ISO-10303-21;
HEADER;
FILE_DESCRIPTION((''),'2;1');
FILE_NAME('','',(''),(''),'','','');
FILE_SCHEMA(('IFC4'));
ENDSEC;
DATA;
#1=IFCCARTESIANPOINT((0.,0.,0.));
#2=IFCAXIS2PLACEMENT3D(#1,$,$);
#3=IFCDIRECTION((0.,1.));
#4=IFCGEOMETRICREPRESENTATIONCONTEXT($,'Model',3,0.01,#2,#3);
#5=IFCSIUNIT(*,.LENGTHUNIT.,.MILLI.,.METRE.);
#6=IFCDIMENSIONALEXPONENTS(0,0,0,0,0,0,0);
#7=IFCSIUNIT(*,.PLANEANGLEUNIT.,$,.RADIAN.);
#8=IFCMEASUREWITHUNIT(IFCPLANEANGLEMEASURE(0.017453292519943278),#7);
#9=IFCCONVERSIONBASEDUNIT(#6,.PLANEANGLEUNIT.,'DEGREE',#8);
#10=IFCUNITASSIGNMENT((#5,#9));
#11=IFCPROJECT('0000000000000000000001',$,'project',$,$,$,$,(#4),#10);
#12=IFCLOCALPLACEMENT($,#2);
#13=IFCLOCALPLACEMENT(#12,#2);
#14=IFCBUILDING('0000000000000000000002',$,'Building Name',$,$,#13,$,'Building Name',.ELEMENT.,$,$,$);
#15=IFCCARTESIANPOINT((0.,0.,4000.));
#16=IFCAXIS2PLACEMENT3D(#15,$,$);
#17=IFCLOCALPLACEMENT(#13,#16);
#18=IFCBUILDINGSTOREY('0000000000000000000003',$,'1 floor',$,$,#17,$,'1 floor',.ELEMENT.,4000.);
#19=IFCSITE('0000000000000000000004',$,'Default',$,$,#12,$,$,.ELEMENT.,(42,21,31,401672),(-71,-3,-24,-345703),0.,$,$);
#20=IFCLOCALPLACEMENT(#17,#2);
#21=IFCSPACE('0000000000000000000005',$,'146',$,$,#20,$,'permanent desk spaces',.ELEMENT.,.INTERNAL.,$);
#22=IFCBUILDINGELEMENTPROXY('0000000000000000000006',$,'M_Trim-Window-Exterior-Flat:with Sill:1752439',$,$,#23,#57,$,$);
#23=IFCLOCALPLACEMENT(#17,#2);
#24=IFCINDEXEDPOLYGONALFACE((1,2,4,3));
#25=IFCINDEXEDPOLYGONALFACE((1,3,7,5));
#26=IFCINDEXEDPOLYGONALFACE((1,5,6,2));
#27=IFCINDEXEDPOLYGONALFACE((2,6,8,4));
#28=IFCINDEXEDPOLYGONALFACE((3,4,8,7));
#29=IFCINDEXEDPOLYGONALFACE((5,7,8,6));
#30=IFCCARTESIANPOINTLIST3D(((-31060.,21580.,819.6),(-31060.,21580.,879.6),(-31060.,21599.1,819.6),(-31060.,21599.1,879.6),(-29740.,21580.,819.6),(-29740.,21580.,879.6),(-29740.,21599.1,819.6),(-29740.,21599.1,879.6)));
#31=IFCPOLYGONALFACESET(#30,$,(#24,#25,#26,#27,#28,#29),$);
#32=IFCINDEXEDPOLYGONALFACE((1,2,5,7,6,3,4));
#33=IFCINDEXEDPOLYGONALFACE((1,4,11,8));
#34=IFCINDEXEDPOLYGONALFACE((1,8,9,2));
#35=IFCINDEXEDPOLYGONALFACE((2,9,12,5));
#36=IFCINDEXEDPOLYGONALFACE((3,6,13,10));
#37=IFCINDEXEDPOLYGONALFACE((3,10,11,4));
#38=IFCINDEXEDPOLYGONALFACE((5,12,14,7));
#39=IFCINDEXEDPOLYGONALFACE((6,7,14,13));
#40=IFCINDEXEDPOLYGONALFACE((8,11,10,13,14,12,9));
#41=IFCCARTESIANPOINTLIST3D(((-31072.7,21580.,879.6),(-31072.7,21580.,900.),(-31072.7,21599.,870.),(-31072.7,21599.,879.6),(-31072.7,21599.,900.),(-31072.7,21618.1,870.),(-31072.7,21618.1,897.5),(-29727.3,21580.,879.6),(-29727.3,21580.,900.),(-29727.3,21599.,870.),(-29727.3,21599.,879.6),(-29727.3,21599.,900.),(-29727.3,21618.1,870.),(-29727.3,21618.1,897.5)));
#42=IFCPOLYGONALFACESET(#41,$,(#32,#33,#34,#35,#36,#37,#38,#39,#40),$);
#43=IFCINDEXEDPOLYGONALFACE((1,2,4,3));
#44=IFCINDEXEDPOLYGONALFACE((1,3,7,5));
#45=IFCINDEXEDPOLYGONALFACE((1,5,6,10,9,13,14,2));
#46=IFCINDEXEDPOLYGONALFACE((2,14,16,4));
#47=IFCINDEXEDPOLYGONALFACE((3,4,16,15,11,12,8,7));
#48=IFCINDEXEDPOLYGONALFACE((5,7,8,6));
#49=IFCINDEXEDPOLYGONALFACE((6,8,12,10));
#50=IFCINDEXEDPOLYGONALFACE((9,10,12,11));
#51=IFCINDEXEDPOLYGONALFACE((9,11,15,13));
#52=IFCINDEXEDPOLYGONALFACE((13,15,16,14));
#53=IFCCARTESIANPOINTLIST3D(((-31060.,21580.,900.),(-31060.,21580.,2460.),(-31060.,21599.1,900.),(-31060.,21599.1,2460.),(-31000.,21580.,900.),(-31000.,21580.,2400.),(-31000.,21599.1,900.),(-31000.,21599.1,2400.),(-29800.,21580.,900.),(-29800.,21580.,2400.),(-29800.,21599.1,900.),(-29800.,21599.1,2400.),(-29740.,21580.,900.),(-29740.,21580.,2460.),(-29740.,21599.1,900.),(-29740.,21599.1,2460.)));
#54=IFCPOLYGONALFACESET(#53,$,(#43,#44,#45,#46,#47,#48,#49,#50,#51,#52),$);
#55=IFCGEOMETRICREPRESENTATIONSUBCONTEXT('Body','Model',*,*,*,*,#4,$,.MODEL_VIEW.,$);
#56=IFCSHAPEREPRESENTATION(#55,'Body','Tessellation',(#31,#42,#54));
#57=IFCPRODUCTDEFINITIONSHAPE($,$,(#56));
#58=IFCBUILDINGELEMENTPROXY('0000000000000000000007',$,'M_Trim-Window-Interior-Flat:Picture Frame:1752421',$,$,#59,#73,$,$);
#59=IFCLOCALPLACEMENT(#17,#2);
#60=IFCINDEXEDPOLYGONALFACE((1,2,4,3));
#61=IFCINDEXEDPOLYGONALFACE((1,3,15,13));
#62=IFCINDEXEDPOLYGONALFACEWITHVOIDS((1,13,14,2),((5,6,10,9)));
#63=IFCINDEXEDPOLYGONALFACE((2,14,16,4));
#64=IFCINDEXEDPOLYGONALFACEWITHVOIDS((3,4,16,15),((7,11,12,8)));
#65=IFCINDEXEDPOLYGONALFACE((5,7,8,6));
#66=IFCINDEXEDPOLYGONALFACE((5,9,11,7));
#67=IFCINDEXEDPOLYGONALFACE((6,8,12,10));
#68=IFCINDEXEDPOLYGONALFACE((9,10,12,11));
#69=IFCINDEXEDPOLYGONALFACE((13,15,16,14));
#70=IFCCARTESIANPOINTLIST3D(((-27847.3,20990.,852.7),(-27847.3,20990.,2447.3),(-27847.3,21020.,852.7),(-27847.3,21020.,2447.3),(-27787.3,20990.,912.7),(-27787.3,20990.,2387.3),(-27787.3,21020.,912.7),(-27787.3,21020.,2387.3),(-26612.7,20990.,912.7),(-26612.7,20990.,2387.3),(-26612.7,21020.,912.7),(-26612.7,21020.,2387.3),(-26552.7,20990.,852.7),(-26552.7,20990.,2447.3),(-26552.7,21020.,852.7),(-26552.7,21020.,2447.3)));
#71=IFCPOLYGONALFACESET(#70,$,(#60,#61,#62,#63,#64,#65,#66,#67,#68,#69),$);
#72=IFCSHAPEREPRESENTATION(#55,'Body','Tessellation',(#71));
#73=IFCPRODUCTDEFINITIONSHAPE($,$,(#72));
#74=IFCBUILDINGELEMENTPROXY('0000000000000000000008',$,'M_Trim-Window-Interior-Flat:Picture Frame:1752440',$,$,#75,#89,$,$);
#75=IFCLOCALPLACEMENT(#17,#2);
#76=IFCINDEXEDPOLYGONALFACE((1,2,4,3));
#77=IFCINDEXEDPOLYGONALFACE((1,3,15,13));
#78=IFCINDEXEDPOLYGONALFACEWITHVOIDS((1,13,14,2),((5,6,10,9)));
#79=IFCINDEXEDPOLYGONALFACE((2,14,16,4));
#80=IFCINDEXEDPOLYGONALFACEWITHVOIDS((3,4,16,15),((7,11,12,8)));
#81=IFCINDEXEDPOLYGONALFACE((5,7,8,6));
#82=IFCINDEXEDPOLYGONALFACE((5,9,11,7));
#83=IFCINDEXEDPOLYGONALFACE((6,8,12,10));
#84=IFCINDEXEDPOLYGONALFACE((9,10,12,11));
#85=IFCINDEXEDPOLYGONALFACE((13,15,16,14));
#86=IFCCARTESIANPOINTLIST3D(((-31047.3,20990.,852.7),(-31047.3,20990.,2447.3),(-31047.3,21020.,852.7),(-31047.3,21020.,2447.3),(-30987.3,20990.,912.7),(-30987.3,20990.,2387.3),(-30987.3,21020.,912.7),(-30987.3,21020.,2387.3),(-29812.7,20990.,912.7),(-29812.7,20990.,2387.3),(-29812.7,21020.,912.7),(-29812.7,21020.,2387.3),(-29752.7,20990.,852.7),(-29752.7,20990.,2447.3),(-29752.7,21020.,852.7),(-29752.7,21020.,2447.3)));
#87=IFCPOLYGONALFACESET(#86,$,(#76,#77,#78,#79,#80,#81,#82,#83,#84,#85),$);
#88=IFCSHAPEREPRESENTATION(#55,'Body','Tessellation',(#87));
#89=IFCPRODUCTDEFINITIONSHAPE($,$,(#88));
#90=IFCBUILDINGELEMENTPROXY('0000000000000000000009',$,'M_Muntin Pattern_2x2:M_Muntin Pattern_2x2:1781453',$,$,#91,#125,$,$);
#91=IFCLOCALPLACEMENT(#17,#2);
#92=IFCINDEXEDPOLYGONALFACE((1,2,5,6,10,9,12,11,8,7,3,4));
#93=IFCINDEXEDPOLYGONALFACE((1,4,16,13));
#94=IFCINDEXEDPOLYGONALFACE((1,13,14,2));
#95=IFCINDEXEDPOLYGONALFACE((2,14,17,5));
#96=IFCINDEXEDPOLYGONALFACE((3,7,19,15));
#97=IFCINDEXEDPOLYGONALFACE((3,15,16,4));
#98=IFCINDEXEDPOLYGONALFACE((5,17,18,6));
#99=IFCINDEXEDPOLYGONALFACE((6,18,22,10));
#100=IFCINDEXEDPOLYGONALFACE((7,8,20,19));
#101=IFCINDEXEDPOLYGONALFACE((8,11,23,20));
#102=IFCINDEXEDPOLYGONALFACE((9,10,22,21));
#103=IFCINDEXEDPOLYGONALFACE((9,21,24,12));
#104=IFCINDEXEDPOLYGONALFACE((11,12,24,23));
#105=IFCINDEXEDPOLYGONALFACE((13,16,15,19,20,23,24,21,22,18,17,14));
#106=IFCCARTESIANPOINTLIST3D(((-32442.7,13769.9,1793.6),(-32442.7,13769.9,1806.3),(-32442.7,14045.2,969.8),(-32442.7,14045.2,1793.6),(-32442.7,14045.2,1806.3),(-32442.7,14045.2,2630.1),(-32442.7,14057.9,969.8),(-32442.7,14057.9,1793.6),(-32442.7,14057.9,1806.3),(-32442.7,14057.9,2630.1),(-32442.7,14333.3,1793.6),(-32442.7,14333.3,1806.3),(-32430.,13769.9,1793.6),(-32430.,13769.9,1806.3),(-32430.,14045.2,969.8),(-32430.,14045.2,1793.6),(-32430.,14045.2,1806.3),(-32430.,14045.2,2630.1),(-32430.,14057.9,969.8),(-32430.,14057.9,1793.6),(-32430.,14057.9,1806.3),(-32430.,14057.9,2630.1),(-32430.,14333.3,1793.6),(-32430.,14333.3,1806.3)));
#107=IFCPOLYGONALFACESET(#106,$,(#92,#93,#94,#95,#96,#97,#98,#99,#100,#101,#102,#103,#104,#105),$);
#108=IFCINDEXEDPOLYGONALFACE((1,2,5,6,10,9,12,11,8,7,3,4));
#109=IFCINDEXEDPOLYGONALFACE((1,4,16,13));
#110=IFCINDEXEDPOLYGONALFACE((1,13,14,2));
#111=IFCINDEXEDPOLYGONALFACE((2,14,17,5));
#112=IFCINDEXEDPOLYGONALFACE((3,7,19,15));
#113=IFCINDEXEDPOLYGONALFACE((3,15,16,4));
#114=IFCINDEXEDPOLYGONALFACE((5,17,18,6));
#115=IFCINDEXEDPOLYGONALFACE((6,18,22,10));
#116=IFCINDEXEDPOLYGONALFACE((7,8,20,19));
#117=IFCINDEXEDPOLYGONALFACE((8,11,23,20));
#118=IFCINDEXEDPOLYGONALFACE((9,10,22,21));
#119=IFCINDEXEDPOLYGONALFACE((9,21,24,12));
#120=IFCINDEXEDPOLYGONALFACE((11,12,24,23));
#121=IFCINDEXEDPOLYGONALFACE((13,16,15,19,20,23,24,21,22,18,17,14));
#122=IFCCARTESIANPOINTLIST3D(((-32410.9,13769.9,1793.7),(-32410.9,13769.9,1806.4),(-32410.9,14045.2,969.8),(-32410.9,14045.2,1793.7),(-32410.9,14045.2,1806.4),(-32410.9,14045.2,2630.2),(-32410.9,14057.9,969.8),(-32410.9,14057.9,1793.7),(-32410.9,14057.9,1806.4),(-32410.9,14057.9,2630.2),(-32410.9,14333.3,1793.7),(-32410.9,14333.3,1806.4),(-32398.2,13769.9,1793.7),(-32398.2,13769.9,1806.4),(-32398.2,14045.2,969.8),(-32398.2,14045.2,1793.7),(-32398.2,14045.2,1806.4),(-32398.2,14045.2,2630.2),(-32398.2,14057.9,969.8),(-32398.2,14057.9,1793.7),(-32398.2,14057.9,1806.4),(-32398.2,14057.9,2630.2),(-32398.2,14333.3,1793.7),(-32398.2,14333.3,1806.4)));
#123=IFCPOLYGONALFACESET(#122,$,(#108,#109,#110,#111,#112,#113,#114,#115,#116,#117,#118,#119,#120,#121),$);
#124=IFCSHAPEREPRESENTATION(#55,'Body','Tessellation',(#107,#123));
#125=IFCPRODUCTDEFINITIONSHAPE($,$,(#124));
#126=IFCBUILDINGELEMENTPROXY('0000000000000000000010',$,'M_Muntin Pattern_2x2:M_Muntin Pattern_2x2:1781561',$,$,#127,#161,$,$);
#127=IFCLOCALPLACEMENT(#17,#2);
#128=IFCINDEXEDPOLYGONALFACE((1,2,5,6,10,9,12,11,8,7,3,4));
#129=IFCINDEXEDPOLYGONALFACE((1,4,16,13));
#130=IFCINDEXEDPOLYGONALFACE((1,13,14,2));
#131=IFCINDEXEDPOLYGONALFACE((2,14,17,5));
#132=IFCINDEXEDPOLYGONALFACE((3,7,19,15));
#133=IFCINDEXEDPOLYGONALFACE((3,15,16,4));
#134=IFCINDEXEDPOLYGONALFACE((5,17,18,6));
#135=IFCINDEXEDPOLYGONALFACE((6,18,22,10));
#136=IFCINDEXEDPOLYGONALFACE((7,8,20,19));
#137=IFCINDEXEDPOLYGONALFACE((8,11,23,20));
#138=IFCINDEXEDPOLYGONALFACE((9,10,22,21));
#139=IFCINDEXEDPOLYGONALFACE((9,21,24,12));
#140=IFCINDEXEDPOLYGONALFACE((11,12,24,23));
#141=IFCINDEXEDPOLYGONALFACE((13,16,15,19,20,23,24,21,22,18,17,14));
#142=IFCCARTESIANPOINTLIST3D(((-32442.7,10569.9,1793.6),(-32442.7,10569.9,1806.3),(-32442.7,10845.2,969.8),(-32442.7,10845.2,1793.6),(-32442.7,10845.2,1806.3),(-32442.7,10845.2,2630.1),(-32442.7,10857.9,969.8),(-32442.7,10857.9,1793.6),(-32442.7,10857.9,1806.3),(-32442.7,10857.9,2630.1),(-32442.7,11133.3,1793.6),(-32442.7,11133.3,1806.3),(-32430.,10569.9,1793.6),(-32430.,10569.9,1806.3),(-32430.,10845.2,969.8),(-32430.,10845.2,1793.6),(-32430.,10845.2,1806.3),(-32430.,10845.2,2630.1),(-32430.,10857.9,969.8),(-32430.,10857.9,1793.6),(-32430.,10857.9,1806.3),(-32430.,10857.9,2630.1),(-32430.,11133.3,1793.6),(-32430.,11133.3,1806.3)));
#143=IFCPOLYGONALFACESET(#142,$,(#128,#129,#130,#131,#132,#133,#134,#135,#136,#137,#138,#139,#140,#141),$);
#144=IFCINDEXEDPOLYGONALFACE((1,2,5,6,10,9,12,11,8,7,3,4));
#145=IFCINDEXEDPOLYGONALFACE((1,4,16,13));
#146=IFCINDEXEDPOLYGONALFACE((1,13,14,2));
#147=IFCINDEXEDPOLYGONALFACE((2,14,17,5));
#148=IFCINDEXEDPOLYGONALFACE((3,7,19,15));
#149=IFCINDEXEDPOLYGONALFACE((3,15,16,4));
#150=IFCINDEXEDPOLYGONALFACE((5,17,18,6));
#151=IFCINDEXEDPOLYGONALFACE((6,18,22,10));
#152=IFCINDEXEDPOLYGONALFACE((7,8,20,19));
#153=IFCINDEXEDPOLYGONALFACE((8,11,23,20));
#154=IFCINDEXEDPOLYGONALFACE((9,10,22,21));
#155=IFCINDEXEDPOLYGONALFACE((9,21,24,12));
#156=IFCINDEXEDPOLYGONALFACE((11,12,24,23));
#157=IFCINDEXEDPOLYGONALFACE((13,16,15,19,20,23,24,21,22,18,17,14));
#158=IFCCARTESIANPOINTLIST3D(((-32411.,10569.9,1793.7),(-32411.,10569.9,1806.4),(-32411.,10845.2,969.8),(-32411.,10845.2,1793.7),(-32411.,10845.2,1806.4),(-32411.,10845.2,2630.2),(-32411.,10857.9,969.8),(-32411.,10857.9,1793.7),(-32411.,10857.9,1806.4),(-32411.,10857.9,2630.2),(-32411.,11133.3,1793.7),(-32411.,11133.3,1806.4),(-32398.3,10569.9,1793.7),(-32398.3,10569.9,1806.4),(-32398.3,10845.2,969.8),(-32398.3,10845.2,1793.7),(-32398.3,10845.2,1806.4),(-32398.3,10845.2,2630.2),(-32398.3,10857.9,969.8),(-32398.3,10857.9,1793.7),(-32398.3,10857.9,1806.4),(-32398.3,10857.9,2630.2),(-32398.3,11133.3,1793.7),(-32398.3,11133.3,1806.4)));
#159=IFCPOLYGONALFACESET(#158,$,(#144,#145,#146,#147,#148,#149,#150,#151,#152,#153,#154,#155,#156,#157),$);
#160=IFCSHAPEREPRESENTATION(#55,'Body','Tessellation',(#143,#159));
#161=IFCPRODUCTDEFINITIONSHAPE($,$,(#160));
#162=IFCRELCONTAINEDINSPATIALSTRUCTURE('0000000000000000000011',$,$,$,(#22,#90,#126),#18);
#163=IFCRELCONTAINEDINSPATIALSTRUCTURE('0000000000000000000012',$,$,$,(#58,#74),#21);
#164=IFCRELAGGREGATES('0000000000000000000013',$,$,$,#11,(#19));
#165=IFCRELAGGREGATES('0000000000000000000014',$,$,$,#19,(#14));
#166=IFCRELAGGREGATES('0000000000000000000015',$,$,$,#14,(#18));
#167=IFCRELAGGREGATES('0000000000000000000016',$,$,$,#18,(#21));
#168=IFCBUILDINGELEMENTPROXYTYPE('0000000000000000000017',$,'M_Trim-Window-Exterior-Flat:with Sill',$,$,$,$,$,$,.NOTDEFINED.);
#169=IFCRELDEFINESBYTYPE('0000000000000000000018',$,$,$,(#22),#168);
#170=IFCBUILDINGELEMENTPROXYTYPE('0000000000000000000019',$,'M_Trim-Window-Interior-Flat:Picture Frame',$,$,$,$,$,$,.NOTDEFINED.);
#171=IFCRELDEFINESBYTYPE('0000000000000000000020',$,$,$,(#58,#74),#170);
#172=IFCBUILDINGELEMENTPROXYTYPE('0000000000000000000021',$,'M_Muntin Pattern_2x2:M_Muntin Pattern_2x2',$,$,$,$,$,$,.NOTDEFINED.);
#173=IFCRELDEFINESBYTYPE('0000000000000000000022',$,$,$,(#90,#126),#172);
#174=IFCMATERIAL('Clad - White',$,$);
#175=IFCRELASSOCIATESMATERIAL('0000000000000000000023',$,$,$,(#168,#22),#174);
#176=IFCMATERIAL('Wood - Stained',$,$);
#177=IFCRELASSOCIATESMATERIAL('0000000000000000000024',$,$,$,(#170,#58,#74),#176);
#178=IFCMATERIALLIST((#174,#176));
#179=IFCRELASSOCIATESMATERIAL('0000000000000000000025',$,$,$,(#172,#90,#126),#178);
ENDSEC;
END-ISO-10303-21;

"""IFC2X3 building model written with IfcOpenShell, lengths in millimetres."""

from ifc_helpers import new_model, entity, si_unit, converted_unit, direction, frame, frame_2d, origin, place, context, subcontext, project, spatial, polyline, rectangle, outline, extrude, source, transform, mapped, material, material_list, type_object, type_shapes, element, save


model = new_model("IFC2X3")

# Units and contexts
model_context = context("Model", 3, precision=0.01, world=origin(), true_north=direction((0.0, 1.0)))
body_context = subcontext(model_context, "Body", "Model", "MODEL_VIEW")
ifc_project = project(units=[si_unit("LENGTHUNIT", "METRE", prefix="MILLI"), converted_unit("PLANEANGLEUNIT", "DEGREE", entity("IfcPlaneAngleMeasure", 0.017453292519943278), si_unit("PLANEANGLEUNIT", "RADIAN"), dimensions=[0, 0, 0, 0, 0, 0, 0])], contexts=[model_context])

# Site, building, storey
site_placement = place(None, origin())
site = spatial("IfcSite", under=ifc_project, at=site_placement, Name="Default", CompositionType="ELEMENT", RefLatitude=(42, 21, 31, 401672), RefLongitude=(-71, -3, -24, -345703), RefElevation=0.0)
building_placement = place(site_placement, origin())
building = spatial("IfcBuilding", under=site, at=building_placement, Name="Building Name", LongName="Building Name", CompositionType="ELEMENT")
storey_placement = place(building_placement, frame((0.0, 0.0, 4000.0)))
storey = spatial("IfcBuildingStorey", under=building, at=storey_placement, Name="1 floor", LongName="1 floor", CompositionType="ELEMENT", Elevation=4000.0)

# Building element proxy
ifc_material_1 = material(Name="Clad - White")
ifc_material_2 = material(Name="Wood - Stained")
ifc_material_list = material_list([ifc_material_1, ifc_material_2])
building_element_proxy_type_1 = type_object("IfcBuildingElementProxyType", Name="M_Trim-Window-Exterior-Flat:with Sill", PredefinedType="NOTDEFINED", material=ifc_material_1)
shared_shape_1 = source(origin(), body_context, "Body", "SweptSolid", [
    extrude(rectangle(XDim=1320.0, YDim=60.0, at=frame_2d((0.0, 0.0), x_axis=(1.0, 0.0))), frame((0.0, -1550.4, 0.0), z_axis=(0.0, 0.0, 1.0), x_axis=(-1.0, 0.0, 0.0)), (0.0, 0.0, 1.0), 19.0),
    extrude(outline(polyline([(-19.0, -15.2), (0.0, -15.2), (0.0, -5.7), (19.0, -5.7), (19.0, 14.8), (0.0, 14.8), (-19.0, 12.3), (-19.0, -15.2)])), frame((-672.7, -1514.8, 19.0), z_axis=(1.0, 0.0, 0.0), x_axis=(0.0, 0.0, -1.0)), (0.0, 0.0, 1.0), 1345.4),
    extrude(outline(polyline([(-795.0, -660.0), (765.0, -660.0), (765.0, -600.0), (-735.0, -600.0), (-735.0, 600.0), (765.0, 600.0), (765.0, 660.0), (-795.0, 660.0), (-795.0, -660.0)])), frame((0.0, -735.0, 0.0), z_axis=(0.0, 0.0, 1.0), x_axis=(0.0, -1.0, 0.0)), (0.0, 0.0, 1.0), 19.0),
])
type_shapes(building_element_proxy_type_1, [shared_shape_1])
for number, where, z_axis, x_axis, name in (
    (1, (-30400.0, 21580.0, 2400.0), (0.0, 1.0, 0.0), (-1.0, 0.0, 0.0), "M_Trim-Window-Exterior-Flat:with Sill:1752439"),
):
    element("IfcBuildingElementProxy", number, at=place(storey_placement, frame(where, z_axis=z_axis, x_axis=x_axis)), inside=storey, type_object=building_element_proxy_type_1, material=ifc_material_1, Name=name, context=body_context, shape_type="MappedRepresentation", body=[
        mapped(shared_shape_1, transform((0.0, 0.0, 0.0), scale=1.0)),
    ])

# Shared definitions
space_placement = place(storey_placement, origin())
space = spatial("IfcSpace", under=storey, at=space_placement, Name="146", LongName="permanent desk spaces", CompositionType="ELEMENT", InteriorOrExteriorSpace="INTERNAL")

# Building element proxies
building_element_proxy_type_2 = type_object("IfcBuildingElementProxyType", Name="M_Trim-Window-Interior-Flat:Picture Frame", PredefinedType="NOTDEFINED", material=ifc_material_2)
shared_shape_2 = source(origin(), body_context, "Body", "SweptSolid", [
    extrude(outline(polyline([(-647.3, -797.3), (647.3, -797.3), (647.3, 797.3), (-647.3, 797.3), (-647.3, -797.3)]), holes=[polyline([(-587.3, -737.3), (-587.3, 737.3), (587.3, 737.3), (587.3, -737.3), (-587.3, -737.3)])]), frame((0.0, -750.0, 0.0), z_axis=(0.0, 0.0, 1.0), x_axis=(-1.0, 0.0, 0.0)), (0.0, 0.0, 1.0), 30.0),
])
type_shapes(building_element_proxy_type_2, [shared_shape_2])
for number, where, z_axis, x_axis, name in (
    (2, (-27200.0, 21020.0, 2400.0), (0.0, -1.0, 0.0), (1.0, 0.0, 0.0), "M_Trim-Window-Interior-Flat:Picture Frame:1752421"),
    (3, (-30400.0, 21020.0, 2400.0), (0.0, -1.0, 0.0), (1.0, 0.0, 0.0), "M_Trim-Window-Interior-Flat:Picture Frame:1752440"),
):
    element("IfcBuildingElementProxy", number, at=place(space_placement, frame(where, z_axis=z_axis, x_axis=x_axis)), inside=space, type_object=building_element_proxy_type_2, material=ifc_material_2, Name=name, context=body_context, shape_type="MappedRepresentation", body=[
        mapped(shared_shape_2, transform((0.0, 0.0, 0.0), scale=1.0)),
    ])
building_element_proxy_type_3 = type_object("IfcBuildingElementProxyType", Name="M_Muntin Pattern_2x2:M_Muntin Pattern_2x2", PredefinedType="NOTDEFINED", material=ifc_material_list)
shared_shape_3 = source(origin(), body_context, "Body", "SweptSolid", [
    extrude(outline(polyline([(6.4, -6.4), (830.1, -6.4), (830.1, 6.3), (6.4, 6.3), (6.4, 281.7), (-6.3, 281.7), (-6.3, 6.3), (-830.2, 6.3), (-830.2, -6.4), (-6.3, -6.4), (-6.3, -281.7), (6.4, -281.7), (6.4, -6.4)])), frame((0.0, 9.5, 830.1), z_axis=(0.0, 1.0, 0.0), x_axis=(0.0, 0.0, 1.0)), (0.0, 0.0, 1.0), 12.7),
    extrude(outline(polyline([(6.4, -6.4), (830.2, -6.4), (830.2, 6.3), (6.4, 6.3), (6.4, 281.7), (-6.3, 281.7), (-6.3, 6.3), (-830.2, 6.3), (-830.2, -6.4), (-6.3, -6.4), (-6.3, -281.7), (6.4, -281.7), (6.4, -6.4)])), frame((0.0, -22.2, 830.2), z_axis=(0.0, 1.0, 0.0), x_axis=(0.0, 0.0, 1.0)), (0.0, 0.0, 1.0), 12.7),
])
type_shapes(building_element_proxy_type_3, [shared_shape_3])
for number, where, z_axis, x_axis, name in (
    (4, (-32420.5, 14051.6, 969.8), (0.0, 0.0, 1.0), (0.0, 1.0, 0.0), "M_Muntin Pattern_2x2:M_Muntin Pattern_2x2:1781453"),
    (5, (-32420.5, 10851.6, 969.8), (0.0, 0.0, 1.0), (0.0, 1.0, 0.0), "M_Muntin Pattern_2x2:M_Muntin Pattern_2x2:1781561"),
):
    element("IfcBuildingElementProxy", number, at=place(storey_placement, frame(where, z_axis=z_axis, x_axis=x_axis)), inside=storey, type_object=building_element_proxy_type_3, material=ifc_material_list, Name=name, context=body_context, shape_type="MappedRepresentation", body=[
        mapped(shared_shape_3, transform((0.0, 0.0, 0.0), scale=1.0)),
    ])

save(model, "model.ifc")
